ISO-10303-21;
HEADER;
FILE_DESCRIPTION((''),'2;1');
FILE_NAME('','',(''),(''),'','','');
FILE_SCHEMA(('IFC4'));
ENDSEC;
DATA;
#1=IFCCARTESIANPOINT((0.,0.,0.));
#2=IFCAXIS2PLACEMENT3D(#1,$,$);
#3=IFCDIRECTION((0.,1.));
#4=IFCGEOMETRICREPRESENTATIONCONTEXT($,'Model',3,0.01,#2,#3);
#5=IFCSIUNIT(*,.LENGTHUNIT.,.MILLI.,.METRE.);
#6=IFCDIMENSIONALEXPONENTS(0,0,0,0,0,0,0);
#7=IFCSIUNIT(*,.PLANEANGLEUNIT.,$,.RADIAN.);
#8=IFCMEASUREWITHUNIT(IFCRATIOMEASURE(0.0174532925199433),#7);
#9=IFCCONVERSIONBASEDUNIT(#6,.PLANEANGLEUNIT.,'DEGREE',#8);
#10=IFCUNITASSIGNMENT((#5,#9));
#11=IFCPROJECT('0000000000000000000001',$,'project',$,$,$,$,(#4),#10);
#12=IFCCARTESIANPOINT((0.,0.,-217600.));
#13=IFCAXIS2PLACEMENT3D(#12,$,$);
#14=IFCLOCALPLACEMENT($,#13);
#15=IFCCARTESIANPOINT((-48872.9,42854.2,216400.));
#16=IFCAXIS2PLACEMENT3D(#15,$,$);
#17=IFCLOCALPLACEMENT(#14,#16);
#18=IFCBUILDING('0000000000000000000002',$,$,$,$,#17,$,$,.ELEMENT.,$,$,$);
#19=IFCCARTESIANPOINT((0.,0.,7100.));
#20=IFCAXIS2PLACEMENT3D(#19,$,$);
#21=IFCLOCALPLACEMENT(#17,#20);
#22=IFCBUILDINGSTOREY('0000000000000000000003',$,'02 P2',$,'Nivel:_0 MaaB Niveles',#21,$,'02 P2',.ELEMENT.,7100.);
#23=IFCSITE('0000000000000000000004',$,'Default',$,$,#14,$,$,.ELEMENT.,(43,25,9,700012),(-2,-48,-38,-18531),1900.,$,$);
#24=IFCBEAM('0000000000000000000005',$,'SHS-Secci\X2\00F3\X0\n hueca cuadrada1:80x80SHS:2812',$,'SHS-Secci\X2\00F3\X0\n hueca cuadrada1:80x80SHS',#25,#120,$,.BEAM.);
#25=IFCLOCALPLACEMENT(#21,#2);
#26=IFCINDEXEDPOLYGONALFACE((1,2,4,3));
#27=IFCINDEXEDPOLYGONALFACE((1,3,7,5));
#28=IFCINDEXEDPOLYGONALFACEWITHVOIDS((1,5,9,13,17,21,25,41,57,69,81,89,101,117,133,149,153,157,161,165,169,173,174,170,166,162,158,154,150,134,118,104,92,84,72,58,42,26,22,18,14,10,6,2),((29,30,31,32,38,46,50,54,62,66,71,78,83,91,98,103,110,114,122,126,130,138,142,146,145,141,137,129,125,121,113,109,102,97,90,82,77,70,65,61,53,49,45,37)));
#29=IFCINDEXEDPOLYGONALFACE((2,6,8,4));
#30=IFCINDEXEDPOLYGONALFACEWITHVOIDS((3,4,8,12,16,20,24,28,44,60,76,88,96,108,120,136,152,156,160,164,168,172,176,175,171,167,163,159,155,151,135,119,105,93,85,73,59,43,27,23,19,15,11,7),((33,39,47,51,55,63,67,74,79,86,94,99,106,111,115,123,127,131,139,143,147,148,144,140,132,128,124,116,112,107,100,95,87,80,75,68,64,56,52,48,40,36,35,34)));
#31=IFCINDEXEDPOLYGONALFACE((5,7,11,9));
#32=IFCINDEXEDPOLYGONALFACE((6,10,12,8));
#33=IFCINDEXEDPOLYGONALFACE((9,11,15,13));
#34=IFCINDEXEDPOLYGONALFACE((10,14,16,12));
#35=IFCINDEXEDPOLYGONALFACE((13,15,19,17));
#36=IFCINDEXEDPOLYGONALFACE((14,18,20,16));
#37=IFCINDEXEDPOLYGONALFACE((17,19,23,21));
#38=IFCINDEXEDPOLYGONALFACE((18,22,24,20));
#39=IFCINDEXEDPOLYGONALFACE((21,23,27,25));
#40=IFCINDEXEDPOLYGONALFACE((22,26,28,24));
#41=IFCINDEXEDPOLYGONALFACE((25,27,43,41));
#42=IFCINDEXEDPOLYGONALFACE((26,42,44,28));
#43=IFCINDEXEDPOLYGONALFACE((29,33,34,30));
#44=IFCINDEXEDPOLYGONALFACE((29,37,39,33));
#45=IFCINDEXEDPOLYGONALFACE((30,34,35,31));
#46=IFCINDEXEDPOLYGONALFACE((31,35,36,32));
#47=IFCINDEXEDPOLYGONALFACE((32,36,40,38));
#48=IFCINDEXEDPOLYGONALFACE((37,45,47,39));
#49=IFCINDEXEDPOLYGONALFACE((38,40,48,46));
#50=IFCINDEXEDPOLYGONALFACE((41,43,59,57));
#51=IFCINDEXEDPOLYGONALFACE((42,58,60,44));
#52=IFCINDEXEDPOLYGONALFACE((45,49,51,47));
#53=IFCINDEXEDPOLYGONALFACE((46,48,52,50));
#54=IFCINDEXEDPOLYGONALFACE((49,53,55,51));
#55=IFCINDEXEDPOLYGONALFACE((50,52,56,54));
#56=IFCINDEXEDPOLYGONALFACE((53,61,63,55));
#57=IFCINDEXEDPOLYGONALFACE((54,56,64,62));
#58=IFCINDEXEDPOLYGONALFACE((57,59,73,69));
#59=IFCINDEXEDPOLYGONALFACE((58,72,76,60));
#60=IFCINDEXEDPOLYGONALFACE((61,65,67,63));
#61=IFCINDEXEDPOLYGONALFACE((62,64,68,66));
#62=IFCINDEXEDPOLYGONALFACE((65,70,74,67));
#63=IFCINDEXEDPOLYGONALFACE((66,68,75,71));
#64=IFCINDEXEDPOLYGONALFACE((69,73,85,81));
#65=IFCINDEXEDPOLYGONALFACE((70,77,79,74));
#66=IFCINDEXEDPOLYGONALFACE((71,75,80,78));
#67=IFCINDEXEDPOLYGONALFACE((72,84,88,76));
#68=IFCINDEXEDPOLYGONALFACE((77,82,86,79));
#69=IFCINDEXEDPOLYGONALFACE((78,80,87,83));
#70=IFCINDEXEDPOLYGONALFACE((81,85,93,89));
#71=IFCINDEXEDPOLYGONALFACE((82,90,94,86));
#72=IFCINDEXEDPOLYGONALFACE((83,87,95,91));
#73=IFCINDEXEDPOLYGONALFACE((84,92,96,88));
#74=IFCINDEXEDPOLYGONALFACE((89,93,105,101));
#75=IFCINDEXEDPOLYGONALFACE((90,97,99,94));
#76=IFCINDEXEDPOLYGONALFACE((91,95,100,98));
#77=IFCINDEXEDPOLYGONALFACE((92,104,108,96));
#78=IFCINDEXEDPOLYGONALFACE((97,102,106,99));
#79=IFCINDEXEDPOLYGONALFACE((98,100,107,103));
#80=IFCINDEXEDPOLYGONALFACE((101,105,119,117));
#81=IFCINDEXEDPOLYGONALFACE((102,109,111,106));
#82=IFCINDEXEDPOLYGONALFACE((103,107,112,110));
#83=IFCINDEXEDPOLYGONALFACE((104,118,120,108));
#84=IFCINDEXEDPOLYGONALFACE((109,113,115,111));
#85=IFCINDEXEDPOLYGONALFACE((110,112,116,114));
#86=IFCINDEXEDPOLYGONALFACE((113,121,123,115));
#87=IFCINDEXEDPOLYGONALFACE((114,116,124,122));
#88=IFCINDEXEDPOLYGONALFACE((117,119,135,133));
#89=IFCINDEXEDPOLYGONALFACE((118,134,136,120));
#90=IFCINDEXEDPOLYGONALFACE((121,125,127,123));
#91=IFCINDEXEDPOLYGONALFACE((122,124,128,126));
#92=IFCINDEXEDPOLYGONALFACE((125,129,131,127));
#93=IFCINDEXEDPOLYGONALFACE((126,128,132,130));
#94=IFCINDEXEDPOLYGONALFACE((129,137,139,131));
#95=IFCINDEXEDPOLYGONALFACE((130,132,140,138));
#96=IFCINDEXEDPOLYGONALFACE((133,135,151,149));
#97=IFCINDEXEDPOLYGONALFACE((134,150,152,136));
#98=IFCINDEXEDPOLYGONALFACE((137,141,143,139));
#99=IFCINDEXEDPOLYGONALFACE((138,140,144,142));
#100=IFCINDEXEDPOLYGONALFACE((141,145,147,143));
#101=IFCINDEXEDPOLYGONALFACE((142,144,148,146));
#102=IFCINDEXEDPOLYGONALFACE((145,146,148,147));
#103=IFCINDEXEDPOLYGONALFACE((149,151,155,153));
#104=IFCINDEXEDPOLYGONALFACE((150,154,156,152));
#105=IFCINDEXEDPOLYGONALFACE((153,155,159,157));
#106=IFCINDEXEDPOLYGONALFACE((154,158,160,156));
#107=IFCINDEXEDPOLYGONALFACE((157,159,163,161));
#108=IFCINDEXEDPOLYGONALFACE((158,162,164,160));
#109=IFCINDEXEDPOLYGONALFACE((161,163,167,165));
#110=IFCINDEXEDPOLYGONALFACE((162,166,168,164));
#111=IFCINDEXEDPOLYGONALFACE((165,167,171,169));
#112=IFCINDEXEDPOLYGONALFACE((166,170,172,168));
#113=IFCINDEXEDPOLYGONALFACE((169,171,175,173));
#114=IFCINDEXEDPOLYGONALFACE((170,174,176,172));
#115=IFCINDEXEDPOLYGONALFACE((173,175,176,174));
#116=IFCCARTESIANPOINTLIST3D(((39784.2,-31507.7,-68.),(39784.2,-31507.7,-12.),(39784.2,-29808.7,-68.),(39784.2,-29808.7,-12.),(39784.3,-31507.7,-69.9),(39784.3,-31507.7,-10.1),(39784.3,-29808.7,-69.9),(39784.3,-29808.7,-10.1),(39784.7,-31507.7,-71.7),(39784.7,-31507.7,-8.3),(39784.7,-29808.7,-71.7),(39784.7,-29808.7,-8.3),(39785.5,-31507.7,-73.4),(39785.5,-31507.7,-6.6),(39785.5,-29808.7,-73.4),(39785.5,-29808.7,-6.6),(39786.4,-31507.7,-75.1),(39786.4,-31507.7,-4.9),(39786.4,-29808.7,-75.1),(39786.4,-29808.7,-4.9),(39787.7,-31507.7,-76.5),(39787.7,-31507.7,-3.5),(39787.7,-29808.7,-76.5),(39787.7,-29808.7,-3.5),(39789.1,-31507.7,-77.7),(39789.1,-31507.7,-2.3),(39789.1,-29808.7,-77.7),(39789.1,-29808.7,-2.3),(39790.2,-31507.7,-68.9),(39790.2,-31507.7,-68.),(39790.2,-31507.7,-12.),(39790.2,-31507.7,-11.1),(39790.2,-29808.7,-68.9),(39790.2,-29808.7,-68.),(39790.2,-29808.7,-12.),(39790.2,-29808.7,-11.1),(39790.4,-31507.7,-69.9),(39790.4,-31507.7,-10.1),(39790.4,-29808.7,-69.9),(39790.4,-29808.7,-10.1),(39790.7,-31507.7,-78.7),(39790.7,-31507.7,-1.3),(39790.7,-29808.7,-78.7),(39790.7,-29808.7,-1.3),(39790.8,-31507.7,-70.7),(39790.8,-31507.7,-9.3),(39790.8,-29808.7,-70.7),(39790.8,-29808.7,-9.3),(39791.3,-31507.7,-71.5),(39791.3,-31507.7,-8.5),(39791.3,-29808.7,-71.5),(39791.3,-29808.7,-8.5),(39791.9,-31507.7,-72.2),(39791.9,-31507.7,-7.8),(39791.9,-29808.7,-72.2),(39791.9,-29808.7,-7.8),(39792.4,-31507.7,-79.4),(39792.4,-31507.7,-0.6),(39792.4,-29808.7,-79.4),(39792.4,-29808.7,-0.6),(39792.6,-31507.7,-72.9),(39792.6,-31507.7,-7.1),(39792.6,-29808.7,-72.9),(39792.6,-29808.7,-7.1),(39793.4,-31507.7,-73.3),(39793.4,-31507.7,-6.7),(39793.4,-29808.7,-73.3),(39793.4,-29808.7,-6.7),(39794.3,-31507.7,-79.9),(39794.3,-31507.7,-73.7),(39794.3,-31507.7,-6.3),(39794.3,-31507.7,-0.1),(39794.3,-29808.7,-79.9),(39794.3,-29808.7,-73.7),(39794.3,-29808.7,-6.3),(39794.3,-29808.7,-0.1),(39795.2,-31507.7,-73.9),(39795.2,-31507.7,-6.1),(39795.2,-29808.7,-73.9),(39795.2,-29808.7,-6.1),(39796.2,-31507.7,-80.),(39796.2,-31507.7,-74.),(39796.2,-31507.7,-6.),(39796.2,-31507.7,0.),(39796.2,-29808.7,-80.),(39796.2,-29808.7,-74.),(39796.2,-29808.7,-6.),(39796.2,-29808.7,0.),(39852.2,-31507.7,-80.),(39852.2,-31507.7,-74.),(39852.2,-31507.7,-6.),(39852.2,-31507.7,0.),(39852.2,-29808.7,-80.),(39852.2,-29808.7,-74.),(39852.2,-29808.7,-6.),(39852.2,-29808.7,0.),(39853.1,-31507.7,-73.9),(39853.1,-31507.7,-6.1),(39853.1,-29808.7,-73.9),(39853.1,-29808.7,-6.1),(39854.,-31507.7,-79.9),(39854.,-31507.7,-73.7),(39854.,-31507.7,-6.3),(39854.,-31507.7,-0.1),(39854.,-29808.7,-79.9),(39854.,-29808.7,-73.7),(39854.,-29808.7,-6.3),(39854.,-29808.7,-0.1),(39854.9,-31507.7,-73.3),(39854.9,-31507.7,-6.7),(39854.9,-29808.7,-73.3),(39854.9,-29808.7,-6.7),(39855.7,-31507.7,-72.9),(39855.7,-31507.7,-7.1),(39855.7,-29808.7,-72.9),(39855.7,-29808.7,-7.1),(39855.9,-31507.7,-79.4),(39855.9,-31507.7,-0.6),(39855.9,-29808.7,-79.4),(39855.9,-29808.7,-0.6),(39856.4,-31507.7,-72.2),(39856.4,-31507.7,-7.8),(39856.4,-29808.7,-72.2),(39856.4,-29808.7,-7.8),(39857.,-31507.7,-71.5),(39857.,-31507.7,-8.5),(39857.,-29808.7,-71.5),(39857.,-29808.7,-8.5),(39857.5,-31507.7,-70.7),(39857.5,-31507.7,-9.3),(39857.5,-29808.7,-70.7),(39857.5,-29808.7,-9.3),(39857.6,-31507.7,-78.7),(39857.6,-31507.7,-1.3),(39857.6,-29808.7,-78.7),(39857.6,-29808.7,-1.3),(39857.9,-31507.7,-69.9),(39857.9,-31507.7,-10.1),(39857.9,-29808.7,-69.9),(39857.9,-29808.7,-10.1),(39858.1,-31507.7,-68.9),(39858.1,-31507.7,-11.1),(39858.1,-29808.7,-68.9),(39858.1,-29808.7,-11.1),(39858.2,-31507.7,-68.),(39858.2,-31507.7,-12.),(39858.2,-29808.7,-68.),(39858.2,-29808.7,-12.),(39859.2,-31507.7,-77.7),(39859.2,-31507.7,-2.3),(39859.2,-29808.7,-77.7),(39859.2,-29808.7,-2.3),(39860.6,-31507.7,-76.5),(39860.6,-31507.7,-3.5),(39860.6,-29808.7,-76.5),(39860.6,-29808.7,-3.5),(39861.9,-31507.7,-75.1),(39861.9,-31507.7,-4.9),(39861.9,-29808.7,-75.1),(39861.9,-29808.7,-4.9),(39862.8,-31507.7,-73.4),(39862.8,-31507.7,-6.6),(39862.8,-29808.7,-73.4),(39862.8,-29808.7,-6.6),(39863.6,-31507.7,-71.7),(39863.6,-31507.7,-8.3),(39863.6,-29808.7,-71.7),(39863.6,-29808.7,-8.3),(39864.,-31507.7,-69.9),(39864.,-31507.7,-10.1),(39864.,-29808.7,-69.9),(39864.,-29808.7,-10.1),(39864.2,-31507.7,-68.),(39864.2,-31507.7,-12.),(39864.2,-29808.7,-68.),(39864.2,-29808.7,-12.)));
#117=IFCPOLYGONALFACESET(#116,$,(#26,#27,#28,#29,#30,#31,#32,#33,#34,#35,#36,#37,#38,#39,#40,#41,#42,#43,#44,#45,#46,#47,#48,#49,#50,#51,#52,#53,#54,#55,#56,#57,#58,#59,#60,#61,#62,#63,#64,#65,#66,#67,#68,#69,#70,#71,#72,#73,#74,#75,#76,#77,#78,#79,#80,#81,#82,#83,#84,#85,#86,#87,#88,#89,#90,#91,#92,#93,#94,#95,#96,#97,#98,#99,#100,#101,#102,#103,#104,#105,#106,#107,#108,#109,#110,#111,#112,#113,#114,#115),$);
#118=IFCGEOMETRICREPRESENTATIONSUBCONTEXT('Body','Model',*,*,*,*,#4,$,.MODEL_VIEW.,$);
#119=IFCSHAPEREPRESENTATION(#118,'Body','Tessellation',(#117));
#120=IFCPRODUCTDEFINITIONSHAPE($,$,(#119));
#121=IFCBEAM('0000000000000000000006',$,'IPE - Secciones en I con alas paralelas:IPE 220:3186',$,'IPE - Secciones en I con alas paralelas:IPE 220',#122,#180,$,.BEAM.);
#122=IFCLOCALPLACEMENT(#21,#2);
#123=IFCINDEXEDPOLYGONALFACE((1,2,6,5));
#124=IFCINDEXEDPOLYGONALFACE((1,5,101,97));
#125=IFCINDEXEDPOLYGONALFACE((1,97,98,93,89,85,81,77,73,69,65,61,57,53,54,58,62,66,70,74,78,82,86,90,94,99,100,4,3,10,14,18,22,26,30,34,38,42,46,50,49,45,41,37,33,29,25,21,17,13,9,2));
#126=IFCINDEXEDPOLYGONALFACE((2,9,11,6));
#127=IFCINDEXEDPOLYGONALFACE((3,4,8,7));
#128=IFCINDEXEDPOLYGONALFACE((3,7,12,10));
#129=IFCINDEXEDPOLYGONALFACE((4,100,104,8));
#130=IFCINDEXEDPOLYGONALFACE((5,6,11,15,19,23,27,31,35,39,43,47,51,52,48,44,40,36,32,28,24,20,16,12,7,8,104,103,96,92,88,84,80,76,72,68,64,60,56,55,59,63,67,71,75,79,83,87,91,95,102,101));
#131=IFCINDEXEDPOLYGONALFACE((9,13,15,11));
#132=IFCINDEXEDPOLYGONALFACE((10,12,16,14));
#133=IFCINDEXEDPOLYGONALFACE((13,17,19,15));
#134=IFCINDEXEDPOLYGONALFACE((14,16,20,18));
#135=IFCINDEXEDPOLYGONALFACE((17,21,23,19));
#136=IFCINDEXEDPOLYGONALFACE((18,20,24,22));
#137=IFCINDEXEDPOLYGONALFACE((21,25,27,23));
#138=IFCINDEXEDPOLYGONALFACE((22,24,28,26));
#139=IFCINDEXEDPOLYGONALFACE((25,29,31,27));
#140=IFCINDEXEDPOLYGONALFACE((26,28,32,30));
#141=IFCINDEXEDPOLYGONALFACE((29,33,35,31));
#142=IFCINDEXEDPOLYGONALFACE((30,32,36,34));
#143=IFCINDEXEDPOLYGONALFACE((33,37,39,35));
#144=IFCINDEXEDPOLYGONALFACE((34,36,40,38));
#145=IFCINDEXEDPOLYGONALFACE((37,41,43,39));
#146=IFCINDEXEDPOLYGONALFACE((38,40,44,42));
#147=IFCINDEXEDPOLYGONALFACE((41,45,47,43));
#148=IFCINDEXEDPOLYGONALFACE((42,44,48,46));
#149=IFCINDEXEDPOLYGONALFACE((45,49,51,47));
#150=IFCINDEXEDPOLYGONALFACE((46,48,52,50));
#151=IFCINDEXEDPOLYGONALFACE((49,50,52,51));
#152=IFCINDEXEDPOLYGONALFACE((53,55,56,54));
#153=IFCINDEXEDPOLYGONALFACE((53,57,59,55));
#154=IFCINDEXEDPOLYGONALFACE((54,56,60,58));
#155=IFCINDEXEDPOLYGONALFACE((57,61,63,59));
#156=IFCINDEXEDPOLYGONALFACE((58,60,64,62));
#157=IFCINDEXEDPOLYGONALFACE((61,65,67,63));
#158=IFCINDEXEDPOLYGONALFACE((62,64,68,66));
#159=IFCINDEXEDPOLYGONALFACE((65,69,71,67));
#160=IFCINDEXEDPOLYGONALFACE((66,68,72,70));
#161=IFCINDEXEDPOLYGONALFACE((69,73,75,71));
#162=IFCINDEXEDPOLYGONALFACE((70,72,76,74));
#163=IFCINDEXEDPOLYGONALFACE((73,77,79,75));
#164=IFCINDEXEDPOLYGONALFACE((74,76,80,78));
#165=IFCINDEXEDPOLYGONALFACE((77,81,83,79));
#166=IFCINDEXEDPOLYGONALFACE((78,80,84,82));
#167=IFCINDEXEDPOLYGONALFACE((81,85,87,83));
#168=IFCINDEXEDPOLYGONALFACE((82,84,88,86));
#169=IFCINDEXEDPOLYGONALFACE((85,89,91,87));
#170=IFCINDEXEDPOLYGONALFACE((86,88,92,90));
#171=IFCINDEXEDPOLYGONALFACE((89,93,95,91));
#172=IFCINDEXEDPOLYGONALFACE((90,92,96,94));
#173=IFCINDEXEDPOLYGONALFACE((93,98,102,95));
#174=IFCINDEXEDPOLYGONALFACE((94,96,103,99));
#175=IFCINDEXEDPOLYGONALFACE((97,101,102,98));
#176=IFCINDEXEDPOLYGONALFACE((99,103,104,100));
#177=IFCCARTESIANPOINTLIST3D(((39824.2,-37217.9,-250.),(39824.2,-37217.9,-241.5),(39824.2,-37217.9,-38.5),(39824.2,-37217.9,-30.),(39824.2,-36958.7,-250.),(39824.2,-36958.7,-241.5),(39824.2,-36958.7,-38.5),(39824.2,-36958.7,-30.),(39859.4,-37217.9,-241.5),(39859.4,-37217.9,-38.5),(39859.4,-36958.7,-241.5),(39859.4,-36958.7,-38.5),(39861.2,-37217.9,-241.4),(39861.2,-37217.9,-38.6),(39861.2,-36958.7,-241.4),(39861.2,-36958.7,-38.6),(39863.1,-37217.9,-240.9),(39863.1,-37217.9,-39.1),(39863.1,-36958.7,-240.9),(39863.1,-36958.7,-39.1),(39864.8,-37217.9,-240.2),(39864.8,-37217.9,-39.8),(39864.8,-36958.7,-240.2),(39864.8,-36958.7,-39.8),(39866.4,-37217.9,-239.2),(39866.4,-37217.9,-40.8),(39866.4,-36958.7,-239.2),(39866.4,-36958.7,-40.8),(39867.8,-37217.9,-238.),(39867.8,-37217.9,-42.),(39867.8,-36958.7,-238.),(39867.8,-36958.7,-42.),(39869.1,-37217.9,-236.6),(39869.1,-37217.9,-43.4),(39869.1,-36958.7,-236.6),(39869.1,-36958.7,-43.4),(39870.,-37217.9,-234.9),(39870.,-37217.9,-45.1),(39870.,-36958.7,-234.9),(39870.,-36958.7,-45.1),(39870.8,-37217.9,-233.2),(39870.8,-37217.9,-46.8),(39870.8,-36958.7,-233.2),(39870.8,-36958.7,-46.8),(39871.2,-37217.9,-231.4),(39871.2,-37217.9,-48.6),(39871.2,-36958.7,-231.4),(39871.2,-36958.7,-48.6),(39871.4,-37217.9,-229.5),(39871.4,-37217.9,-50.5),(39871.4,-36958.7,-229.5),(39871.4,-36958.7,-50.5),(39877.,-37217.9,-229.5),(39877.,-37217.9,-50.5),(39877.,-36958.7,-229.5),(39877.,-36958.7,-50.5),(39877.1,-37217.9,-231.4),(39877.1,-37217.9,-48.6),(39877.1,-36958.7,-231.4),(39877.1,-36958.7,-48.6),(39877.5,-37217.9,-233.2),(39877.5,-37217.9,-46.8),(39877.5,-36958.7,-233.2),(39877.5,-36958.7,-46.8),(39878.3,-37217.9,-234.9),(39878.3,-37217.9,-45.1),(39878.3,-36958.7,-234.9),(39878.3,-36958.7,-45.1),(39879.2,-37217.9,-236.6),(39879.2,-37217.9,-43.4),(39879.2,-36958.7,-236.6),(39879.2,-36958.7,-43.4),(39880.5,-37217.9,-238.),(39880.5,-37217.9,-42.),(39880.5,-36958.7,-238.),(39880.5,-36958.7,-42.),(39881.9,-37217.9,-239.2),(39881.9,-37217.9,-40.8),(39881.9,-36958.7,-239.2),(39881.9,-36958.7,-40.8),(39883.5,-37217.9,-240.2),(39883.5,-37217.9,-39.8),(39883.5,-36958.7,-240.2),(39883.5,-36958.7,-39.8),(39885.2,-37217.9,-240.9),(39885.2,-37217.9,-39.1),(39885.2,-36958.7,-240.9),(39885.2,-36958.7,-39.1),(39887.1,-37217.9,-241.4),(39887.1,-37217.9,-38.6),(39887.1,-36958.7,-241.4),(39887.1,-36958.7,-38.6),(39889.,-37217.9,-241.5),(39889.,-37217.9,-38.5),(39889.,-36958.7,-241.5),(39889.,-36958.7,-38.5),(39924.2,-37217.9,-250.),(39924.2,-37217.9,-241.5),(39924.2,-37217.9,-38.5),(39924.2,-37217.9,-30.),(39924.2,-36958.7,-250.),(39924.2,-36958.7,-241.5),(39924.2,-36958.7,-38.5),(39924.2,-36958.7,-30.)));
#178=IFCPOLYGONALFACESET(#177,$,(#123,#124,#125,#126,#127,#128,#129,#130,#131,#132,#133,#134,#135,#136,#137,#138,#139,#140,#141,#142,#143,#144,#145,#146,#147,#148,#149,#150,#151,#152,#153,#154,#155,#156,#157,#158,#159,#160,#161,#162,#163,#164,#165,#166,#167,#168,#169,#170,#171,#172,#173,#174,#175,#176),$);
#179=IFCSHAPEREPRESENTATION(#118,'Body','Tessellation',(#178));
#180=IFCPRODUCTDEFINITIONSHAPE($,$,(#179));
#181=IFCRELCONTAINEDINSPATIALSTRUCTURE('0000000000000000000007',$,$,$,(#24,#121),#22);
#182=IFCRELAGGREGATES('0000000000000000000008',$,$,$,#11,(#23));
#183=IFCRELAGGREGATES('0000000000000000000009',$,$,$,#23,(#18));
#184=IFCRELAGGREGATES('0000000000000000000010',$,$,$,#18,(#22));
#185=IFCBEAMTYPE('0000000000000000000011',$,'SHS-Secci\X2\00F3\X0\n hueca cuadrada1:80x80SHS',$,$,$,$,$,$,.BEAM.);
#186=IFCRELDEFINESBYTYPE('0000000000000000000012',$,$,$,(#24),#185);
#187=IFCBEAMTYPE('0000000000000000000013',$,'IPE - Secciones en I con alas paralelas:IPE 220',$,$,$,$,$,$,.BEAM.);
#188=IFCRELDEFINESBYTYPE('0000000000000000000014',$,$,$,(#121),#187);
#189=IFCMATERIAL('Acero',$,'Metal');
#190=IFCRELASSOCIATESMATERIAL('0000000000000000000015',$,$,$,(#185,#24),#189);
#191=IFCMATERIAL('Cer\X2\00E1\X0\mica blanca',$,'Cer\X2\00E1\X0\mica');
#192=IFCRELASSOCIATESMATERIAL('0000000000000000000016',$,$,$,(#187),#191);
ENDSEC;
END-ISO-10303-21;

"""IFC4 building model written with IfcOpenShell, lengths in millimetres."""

from ifc_helpers import new_model, entity, si_unit, converted_unit, direction, frame, origin, place, context, subcontext, project, spatial, indexed_curve, outline, extrude, source, transform, mapped, material, type_object, type_shapes, element, save


model = new_model("IFC4")

# Units and contexts
model_context = context("Model", 3, precision=0.01, world=origin(), true_north=direction((0.0, 1.0)))
body_context = subcontext(model_context, "Body", "Model", "MODEL_VIEW")
ifc_project = project(units=[si_unit("LENGTHUNIT", "METRE", prefix="MILLI"), converted_unit("PLANEANGLEUNIT", "DEGREE", entity("IfcRatioMeasure", 0.0174532925199433), si_unit("PLANEANGLEUNIT", "RADIAN"), dimensions=[0, 0, 0, 0, 0, 0, 0])], contexts=[model_context])

# Site, building, storey
site_placement = place(None, frame((0.0, 0.0, -217600.0)))
site = spatial("IfcSite", under=ifc_project, at=site_placement, Name="Default", CompositionType="ELEMENT", RefLatitude=(43, 25, 9, 700012), RefLongitude=(-2, -48, -38, -18531), RefElevation=1900.0)
building_placement = place(site_placement, frame((-48872.9, 42854.2, 216400.0)))
building = spatial("IfcBuilding", under=site, at=building_placement, CompositionType="ELEMENT")
storey_placement = place(building_placement, frame((0.0, 0.0, 7100.0)))
storey = spatial("IfcBuildingStorey", under=building, at=storey_placement, Name="02 P2", ObjectType="Nivel:_0 MaaB Niveles", LongName="02 P2", CompositionType="ELEMENT", Elevation=7100.0)

# Shared definitions
ifc_material_1 = material(Name="Acero", Category="Metal")

# Beams
beam_type_1 = type_object("IfcBeamType", Name="SHS-Sección hueca cuadrada1:80x80SHS", PredefinedType="BEAM", material=ifc_material_1)
shared_shape_1 = source(origin(), body_context, "Body", "SweptSolid", [
    extrude(outline(indexed_curve([(-40.0, -28.0), (-39.9, -29.9), (-39.4, -31.7), (-38.7, -33.4), (-37.7, -35.1), (-36.5, -36.5), (-35.1, -37.7), (-33.4, -38.7), (-31.7, -39.4), (-29.9, -39.9), (-28.0, -40.0), (28.0, -40.0), (29.9, -39.9), (31.7, -39.4), (33.4, -38.7), (35.1, -37.7), (36.5, -36.5), (37.7, -35.1), (38.7, -33.4), (39.4, -31.7), (39.9, -29.9), (40.0, -28.0), (40.0, 28.0), (39.9, 29.9), (39.4, 31.7), (38.7, 33.4), (37.7, 35.1), (36.5, 36.5), (35.1, 37.7), (33.4, 38.7), (31.7, 39.4), (29.9, 39.9), (28.0, 40.0), (-28.0, 40.0), (-29.9, 39.9), (-31.7, 39.4), (-33.4, 38.7), (-35.1, 37.7), (-36.5, 36.5), (-37.7, 35.1), (-38.7, 33.4), (-39.4, 31.7), (-39.9, 29.9), (-40.0, 28.0), (-40.0, -28.0)], self_intersect=False), holes=[indexed_curve([(28.0, -34.0), (-28.0, -34.0), (-28.9, -33.9), (-29.9, -33.7), (-30.7, -33.3), (-31.5, -32.9), (-32.2, -32.2), (-32.9, -31.5), (-33.3, -30.7), (-33.7, -29.9), (-33.9, -28.9), (-34.0, -28.0), (-34.0, 28.0), (-33.9, 28.9), (-33.7, 29.9), (-33.3, 30.7), (-32.9, 31.5), (-32.2, 32.2), (-31.5, 32.9), (-30.7, 33.3), (-29.9, 33.7), (-28.9, 33.9), (-28.0, 34.0), (28.0, 34.0), (28.9, 33.9), (29.9, 33.7), (30.7, 33.3), (31.5, 32.9), (32.2, 32.2), (32.9, 31.5), (33.3, 30.7), (33.7, 29.9), (33.9, 28.9), (34.0, 28.0), (34.0, -28.0), (33.9, -28.9), (33.7, -29.9), (33.3, -30.7), (32.9, -31.5), (32.2, -32.2), (31.5, -32.9), (30.7, -33.3), (29.9, -33.7), (28.9, -33.9), (28.0, -34.0)], self_intersect=False)]), frame((-827.5, 0.0, 0.0), z_axis=(1.0, 0.0, 0.0), x_axis=(0.0, -1.0, 0.0)), (0.0, 0.0, 1.0), 1699.0),
])
type_shapes(beam_type_1, [shared_shape_1])
beam_1_placement = place(storey_placement, frame((39824.2, -30636.2, -40.0), z_axis=(0.0, 0.0, 1.0), x_axis=(0.0, -1.0, 0.0)))
element("IfcBeam", 1, at=beam_1_placement, inside=storey, type_object=beam_type_1, material=ifc_material_1, Name="SHS-Sección hueca cuadrada1:80x80SHS:2812", ObjectType="SHS-Sección hueca cuadrada1:80x80SHS", PredefinedType="BEAM", context=body_context, shape_type="MappedRepresentation", body=[
    mapped(shared_shape_1, transform((0.0, 0.0, 0.0), scale=1.0)),
])
ifc_material_2 = material(Name="Cerámica blanca", Category="Cerámica")
beam_type_2 = type_object("IfcBeamType", Name="IPE - Secciones en I con alas paralelas:IPE 220", PredefinedType="BEAM", material=ifc_material_2)
shared_shape_2 = source(origin(), body_context, "Body", "SweptSolid", [
    extrude(outline(indexed_curve([(-110.0, -50.0), (-101.5, -50.0), (-101.5, -14.8), (-101.4, -12.9), (-100.9, -11.1), (-100.2, -9.4), (-99.2, -7.7), (-98.0, -6.3), (-96.6, -5.1), (-94.9, -4.1), (-93.2, -3.4), (-91.4, -2.9), (-89.5, -2.8), (89.5, -2.8), (91.4, -2.9), (93.2, -3.4), (94.9, -4.1), (96.6, -5.1), (98.0, -6.3), (99.2, -7.7), (100.2, -9.4), (100.9, -11.1), (101.4, -12.9), (101.5, -14.8), (101.5, -50.0), (110.0, -50.0), (110.0, 50.0), (101.5, 50.0), (101.5, 14.8), (101.4, 12.9), (100.9, 11.1), (100.2, 9.4), (99.2, 7.7), (98.0, 6.3), (96.6, 5.1), (94.9, 4.1), (93.2, 3.4), (91.4, 2.9), (89.5, 2.8), (-89.5, 2.8), (-91.4, 2.9), (-93.2, 3.4), (-94.9, 4.1), (-96.6, 5.1), (-98.0, 6.3), (-99.2, 7.7), (-100.2, 9.4), (-100.9, 11.1), (-101.4, 12.9), (-101.5, 14.8), (-101.5, 50.0), (-110.0, 50.0), (-110.0, -50.0)], self_intersect=False)), frame((-41.7, 0.0, 0.0), z_axis=(1.0, 0.0, 0.0), x_axis=(0.0, 0.0, -1.0)), (0.0, 0.0, 1.0), 259.2),
])
type_shapes(beam_type_2, [shared_shape_2])
beam_2_placement = place(storey_placement, frame((39874.2, -37176.2, -140.0), z_axis=(0.0, 0.0, 1.0), x_axis=(0.0, 1.0, 0.0)))
element("IfcBeam", 2, at=beam_2_placement, inside=storey, type_object=beam_type_2, Name="IPE - Secciones en I con alas paralelas:IPE 220:3186", ObjectType="IPE - Secciones en I con alas paralelas:IPE 220", PredefinedType="BEAM", context=body_context, shape_type="MappedRepresentation", body=[
    mapped(shared_shape_2, transform((0.0, 0.0, 0.0), scale=1.0)),
])

save(model, "model.ifc")
